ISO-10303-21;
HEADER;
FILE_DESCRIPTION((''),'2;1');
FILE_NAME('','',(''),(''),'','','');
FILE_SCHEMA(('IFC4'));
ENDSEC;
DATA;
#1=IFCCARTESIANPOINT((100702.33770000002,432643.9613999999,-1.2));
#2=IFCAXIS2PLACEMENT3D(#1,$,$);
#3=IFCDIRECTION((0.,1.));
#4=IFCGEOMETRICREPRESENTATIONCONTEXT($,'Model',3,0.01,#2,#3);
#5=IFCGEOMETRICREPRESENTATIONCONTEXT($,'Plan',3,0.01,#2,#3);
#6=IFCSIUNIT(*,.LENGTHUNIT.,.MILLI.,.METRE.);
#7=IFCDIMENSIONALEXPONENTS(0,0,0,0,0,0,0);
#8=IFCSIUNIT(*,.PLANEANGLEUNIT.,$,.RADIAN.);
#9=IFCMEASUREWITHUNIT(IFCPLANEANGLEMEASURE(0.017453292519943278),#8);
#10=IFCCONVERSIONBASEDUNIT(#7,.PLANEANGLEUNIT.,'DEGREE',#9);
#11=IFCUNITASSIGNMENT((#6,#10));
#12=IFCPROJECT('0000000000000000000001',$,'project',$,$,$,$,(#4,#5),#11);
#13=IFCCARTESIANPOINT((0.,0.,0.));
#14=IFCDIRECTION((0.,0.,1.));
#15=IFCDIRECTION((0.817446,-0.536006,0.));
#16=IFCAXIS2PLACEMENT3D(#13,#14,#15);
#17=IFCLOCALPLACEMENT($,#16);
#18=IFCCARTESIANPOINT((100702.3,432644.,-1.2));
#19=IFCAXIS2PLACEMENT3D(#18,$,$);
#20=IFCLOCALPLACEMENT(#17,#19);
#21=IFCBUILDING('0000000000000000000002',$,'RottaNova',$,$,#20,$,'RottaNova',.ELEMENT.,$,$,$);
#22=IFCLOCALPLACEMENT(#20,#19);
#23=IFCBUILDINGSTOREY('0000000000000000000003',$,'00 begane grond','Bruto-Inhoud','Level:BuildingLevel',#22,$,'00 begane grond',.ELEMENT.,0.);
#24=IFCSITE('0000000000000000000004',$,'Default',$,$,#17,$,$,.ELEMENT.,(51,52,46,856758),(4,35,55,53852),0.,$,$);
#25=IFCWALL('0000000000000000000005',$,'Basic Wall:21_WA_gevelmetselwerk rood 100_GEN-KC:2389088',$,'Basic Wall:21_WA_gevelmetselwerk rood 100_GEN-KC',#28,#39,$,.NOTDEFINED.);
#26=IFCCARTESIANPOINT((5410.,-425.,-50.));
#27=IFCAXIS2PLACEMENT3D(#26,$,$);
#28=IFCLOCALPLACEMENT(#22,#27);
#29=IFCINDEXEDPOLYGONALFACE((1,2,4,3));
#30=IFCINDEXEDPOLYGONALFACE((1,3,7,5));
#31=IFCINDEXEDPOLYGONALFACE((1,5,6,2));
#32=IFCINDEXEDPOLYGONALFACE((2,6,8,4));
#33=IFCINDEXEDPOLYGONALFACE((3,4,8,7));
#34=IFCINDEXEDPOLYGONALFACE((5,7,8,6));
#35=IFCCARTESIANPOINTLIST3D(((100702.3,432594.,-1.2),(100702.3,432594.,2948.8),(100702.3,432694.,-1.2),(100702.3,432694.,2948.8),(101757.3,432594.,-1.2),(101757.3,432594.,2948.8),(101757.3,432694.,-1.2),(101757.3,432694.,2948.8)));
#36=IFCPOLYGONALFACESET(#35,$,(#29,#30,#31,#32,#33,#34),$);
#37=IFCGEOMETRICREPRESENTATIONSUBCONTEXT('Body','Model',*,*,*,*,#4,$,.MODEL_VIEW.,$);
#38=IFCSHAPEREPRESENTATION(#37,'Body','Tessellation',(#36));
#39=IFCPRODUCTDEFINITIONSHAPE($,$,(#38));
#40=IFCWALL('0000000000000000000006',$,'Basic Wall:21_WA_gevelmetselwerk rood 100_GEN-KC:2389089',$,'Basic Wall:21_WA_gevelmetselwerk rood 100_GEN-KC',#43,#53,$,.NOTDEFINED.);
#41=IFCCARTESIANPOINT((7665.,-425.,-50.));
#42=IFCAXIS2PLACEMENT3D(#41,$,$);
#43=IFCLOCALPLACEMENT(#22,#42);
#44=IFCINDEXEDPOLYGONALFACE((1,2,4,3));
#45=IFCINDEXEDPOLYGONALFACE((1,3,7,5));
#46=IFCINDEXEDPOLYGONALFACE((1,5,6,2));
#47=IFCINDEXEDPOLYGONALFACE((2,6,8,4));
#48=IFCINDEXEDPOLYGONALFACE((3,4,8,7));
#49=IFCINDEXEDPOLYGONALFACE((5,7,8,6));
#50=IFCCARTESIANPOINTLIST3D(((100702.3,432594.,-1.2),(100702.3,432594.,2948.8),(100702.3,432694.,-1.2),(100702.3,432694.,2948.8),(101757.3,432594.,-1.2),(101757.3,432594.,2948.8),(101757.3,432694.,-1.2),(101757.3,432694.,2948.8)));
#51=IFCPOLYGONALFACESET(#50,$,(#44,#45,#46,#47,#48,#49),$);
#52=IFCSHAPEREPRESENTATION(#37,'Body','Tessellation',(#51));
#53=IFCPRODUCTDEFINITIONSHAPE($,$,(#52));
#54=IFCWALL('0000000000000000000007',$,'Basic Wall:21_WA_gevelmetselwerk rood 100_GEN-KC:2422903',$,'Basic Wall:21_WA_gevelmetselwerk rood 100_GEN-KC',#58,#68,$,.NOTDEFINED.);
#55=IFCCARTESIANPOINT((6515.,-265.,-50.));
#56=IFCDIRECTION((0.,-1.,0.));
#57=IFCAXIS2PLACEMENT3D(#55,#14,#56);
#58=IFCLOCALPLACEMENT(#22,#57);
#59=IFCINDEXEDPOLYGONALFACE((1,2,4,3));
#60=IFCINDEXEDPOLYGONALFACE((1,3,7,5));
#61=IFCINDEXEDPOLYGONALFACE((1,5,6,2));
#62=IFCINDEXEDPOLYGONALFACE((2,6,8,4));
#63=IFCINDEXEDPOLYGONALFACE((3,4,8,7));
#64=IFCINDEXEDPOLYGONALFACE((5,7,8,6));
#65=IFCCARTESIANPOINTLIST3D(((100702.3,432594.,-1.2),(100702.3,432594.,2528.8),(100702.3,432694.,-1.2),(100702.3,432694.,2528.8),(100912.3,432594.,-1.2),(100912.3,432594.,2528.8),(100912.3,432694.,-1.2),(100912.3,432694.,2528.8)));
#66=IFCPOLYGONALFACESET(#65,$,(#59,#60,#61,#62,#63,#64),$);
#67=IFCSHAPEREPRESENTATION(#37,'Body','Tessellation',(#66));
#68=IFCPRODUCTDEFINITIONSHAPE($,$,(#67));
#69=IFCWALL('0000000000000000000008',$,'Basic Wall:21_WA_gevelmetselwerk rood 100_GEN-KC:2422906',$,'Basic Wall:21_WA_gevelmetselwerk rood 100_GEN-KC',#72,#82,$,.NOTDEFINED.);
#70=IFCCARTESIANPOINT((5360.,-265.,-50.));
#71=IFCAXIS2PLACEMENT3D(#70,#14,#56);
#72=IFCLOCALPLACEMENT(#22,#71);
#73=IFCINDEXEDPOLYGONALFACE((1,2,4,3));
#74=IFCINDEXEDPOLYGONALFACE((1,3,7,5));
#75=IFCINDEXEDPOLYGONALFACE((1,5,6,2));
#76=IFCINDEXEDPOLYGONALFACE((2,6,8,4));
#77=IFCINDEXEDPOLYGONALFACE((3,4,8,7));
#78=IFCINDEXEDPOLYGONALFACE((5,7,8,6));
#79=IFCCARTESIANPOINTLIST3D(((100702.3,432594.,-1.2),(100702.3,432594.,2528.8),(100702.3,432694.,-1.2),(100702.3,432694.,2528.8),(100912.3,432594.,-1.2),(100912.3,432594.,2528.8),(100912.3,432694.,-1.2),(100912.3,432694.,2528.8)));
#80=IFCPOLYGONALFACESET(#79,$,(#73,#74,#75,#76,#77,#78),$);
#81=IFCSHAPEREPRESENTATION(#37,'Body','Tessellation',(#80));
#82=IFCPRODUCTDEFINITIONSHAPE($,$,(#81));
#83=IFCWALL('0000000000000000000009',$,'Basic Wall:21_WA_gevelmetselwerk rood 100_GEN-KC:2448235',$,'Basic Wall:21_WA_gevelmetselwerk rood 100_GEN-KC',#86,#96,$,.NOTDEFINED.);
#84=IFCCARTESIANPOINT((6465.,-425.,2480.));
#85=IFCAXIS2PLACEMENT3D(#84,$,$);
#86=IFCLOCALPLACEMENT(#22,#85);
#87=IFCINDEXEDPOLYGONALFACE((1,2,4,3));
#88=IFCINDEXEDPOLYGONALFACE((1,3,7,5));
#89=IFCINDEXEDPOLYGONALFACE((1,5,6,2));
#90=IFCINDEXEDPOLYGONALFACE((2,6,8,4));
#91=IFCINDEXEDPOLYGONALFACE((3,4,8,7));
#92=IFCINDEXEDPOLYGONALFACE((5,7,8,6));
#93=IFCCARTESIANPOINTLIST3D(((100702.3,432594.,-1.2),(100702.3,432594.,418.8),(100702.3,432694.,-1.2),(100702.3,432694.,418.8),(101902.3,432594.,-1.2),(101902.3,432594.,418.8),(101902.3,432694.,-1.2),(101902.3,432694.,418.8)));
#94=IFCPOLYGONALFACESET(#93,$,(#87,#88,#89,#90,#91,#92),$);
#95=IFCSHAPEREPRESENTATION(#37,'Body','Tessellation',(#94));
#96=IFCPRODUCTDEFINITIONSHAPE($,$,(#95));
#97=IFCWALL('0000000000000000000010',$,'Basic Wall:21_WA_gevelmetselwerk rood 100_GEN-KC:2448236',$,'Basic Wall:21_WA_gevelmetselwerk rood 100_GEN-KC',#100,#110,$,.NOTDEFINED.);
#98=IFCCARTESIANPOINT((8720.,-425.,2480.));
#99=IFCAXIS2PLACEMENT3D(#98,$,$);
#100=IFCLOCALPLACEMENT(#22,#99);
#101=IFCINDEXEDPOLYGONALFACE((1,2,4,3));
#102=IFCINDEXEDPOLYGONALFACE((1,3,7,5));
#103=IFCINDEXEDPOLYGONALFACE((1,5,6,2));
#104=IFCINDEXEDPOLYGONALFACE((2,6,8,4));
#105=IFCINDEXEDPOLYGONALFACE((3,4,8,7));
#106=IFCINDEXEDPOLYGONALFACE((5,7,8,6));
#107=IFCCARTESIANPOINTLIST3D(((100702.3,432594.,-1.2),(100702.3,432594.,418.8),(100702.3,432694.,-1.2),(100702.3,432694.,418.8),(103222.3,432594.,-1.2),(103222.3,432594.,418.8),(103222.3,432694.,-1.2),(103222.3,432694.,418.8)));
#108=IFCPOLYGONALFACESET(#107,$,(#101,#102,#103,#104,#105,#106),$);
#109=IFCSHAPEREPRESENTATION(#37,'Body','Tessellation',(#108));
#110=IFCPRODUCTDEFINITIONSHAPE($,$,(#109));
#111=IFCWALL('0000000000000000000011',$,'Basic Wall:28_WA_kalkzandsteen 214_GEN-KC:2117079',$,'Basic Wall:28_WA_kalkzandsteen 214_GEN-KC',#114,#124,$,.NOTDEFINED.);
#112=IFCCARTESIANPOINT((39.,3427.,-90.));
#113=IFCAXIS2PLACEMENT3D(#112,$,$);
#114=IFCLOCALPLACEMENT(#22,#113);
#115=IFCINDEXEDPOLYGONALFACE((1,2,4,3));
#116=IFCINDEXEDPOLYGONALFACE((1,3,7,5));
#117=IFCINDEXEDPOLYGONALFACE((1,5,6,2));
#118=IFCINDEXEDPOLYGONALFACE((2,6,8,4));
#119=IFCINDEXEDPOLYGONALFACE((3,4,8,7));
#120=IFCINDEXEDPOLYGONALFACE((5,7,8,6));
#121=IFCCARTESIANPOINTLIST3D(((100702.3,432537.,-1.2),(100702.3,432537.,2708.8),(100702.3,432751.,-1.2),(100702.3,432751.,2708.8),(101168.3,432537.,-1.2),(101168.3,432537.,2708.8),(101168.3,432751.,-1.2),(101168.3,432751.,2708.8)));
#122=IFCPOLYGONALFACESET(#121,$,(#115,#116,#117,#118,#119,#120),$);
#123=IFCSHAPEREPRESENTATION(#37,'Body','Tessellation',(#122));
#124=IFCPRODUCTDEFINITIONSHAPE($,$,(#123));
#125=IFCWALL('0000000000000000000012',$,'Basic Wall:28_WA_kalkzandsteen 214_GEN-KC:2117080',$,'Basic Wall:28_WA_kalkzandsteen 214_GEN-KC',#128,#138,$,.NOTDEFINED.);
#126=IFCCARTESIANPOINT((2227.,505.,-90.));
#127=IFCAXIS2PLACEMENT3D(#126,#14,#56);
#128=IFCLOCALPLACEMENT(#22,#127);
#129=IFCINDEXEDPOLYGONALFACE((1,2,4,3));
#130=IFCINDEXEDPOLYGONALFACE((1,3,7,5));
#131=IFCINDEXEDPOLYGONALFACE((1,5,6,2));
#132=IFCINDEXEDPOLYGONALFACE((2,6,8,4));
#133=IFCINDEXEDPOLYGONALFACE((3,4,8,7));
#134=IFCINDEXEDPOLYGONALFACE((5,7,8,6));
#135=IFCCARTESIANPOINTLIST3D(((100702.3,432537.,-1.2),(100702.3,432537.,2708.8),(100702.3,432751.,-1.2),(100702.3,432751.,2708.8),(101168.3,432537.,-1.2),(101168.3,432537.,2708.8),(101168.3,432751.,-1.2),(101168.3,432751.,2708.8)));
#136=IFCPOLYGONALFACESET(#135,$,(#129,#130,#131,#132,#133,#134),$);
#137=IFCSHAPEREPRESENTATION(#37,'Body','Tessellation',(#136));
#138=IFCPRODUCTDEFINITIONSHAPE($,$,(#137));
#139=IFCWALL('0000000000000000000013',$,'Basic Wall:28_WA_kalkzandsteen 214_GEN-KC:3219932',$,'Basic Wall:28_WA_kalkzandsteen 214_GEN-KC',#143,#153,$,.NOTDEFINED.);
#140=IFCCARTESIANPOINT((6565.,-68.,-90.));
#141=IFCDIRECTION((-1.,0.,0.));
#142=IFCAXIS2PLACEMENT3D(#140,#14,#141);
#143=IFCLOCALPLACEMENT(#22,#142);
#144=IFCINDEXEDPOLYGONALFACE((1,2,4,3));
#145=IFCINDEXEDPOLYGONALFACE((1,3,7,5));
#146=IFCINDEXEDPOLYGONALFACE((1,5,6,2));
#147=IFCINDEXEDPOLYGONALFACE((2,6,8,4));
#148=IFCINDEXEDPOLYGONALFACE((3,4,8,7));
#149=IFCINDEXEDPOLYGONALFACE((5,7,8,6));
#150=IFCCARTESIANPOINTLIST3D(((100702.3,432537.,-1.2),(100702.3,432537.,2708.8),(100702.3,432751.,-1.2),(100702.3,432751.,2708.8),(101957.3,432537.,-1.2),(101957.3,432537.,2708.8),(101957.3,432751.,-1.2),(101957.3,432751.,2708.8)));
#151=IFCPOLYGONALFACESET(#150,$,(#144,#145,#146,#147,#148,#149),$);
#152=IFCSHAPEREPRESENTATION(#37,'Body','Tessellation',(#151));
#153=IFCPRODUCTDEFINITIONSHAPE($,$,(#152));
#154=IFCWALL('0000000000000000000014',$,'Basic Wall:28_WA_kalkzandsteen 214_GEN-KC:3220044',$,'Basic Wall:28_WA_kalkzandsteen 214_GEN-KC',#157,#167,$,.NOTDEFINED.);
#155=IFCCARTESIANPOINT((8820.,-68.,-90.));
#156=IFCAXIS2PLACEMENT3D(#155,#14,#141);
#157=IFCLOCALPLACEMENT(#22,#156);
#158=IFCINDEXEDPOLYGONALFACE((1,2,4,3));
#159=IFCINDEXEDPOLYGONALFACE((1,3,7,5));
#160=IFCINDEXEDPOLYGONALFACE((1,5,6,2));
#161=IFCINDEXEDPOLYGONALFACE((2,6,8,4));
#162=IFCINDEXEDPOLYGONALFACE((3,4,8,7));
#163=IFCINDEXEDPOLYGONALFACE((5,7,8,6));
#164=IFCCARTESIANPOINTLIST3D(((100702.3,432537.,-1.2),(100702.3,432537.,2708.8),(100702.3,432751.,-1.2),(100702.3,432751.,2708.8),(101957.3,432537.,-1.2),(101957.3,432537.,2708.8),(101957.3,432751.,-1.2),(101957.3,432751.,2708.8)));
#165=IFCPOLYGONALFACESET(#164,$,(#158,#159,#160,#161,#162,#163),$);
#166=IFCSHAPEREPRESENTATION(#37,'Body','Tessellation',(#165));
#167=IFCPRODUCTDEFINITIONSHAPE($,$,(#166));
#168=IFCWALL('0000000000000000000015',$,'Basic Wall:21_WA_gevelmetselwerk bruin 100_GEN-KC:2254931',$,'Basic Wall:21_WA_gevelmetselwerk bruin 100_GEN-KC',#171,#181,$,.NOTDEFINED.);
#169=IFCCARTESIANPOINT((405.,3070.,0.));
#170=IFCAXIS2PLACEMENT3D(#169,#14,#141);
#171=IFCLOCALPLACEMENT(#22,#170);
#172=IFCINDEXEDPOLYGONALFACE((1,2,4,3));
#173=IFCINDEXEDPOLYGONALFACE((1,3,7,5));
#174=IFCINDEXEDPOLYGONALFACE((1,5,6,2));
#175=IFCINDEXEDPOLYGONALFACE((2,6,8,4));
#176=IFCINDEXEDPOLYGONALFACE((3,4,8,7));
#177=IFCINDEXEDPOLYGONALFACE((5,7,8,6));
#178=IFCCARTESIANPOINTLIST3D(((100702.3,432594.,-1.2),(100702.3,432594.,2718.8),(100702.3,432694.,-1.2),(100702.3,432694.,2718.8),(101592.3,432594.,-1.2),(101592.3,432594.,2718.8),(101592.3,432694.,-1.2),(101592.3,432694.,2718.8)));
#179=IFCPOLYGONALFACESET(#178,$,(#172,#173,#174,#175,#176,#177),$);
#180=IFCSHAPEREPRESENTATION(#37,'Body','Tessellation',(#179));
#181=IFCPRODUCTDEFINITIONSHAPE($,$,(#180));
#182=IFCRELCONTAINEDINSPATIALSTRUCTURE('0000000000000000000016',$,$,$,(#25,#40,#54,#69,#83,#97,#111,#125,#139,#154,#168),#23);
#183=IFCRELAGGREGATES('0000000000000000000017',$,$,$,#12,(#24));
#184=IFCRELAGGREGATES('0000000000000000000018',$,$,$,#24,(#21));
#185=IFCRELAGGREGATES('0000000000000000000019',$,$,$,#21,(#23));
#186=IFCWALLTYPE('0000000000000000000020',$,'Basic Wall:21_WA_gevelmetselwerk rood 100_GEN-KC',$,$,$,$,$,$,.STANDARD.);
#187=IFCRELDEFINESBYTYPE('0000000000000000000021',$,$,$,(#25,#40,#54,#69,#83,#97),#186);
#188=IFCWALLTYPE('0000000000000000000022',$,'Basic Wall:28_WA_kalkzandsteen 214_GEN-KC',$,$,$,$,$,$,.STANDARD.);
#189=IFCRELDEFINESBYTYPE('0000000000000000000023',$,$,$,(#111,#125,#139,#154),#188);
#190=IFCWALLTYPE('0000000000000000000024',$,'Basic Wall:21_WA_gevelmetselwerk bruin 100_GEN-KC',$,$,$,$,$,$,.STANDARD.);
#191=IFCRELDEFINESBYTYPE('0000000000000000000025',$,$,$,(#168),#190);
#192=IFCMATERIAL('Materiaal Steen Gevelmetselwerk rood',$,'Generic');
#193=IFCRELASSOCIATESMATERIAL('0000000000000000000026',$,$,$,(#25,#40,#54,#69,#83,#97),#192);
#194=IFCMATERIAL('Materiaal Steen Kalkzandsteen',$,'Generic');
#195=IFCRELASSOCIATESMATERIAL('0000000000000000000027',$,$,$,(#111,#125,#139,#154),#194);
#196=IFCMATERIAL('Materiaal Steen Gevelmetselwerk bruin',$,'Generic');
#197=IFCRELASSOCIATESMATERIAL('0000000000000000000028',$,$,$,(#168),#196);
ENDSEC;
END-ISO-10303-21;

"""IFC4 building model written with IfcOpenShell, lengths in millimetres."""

from ifc_helpers import new_model, entity, si_unit, converted_unit, direction, frame, place, context, subcontext, project, spatial, indexed_curve, outline, extrude, material, type_object, element, save


model = new_model("IFC4")

# Units and contexts
model_context = context("Model", 3, precision=0.01, world=frame((100702.33770000002, 432643.9613999999, -1.2)), true_north=direction((0.0, 1.0)))
plan_context = context("Plan", 3, precision=0.01, world=frame((100702.33770000002, 432643.9613999999, -1.2)), true_north=direction((0.0, 1.0)))
body_context = subcontext(model_context, "Body", "Model", "MODEL_VIEW")
ifc_project = project(units=[si_unit("LENGTHUNIT", "METRE", prefix="MILLI"), converted_unit("PLANEANGLEUNIT", "DEGREE", entity("IfcPlaneAngleMeasure", 0.017453292519943278), si_unit("PLANEANGLEUNIT", "RADIAN"), dimensions=[0, 0, 0, 0, 0, 0, 0])], contexts=[model_context, plan_context])

# Site, building, storey
site_placement = place(None, frame((0.0, 0.0, 0.0), z_axis=(0.0, 0.0, 1.0), x_axis=(0.817446, -0.536006, 0.0)))
site = spatial("IfcSite", under=ifc_project, at=site_placement, Name="Default", CompositionType="ELEMENT", RefLatitude=(51, 52, 46, 856758), RefLongitude=(4, 35, 55, 53852), RefElevation=0.0)
building_placement = place(site_placement, frame((100702.3, 432644.0, -1.2)))
building = spatial("IfcBuilding", under=site, at=building_placement, Name="RottaNova", LongName="RottaNova", CompositionType="ELEMENT")
storey_placement = place(building_placement, frame((100702.3, 432644.0, -1.2)))
storey = spatial("IfcBuildingStorey", under=building, at=storey_placement, Name="00 begane grond", Description="Bruto-Inhoud", ObjectType="Level:BuildingLevel", LongName="00 begane grond", CompositionType="ELEMENT", Elevation=0.0)

# Walls
ifc_material_1 = material(Name="Materiaal Steen Gevelmetselwerk rood", Category="Generic")
wall_type_1 = type_object("IfcWallType", Name="Basic Wall:21_WA_gevelmetselwerk rood 100_GEN-KC", PredefinedType="STANDARD")
wall_1_placement = place(storey_placement, frame((5410.0, -425.0, -50.0)))
element("IfcWall", 1, at=wall_1_placement, inside=storey, type_object=wall_type_1, material=ifc_material_1, Name="Basic Wall:21_WA_gevelmetselwerk rood 100_GEN-KC:2389088", ObjectType="Basic Wall:21_WA_gevelmetselwerk rood 100_GEN-KC", PredefinedType="NOTDEFINED", context=body_context, shape_type="SweptSolid", body=[
    extrude(outline(indexed_curve([(1055.0, 50.0), (0.0, 50.0), (0.0, -50.0), (1055.0, -50.0), (1055.0, 50.0)], self_intersect=False)), frame((100702.3, 432644.0, -1.2)), (0.0, 0.0, 1.0), 2950.0),
])
wall_2_placement = place(storey_placement, frame((7665.0, -425.0, -50.0)))
element("IfcWall", 2, at=wall_2_placement, inside=storey, type_object=wall_type_1, material=ifc_material_1, Name="Basic Wall:21_WA_gevelmetselwerk rood 100_GEN-KC:2389089", ObjectType="Basic Wall:21_WA_gevelmetselwerk rood 100_GEN-KC", PredefinedType="NOTDEFINED", context=body_context, shape_type="SweptSolid", body=[
    extrude(outline(indexed_curve([(1055.0, 50.0), (0.0, 50.0), (0.0, -50.0), (1055.0, -50.0), (1055.0, 50.0)], self_intersect=False)), frame((100702.3, 432644.0, -1.2)), (0.0, 0.0, 1.0), 2950.0),
])
wall_3_placement = place(storey_placement, frame((6515.0, -265.0, -50.0), z_axis=(0.0, 0.0, 1.0), x_axis=(0.0, -1.0, 0.0)))
element("IfcWall", 3, at=wall_3_placement, inside=storey, type_object=wall_type_1, material=ifc_material_1, Name="Basic Wall:21_WA_gevelmetselwerk rood 100_GEN-KC:2422903", ObjectType="Basic Wall:21_WA_gevelmetselwerk rood 100_GEN-KC", PredefinedType="NOTDEFINED", context=body_context, shape_type="SweptSolid", body=[
    extrude(outline(indexed_curve([(210.0, 50.0), (0.0, 50.0), (0.0, -50.0), (210.0, -50.0), (210.0, 50.0)], self_intersect=False)), frame((100702.3, 432644.0, -1.2)), (0.0, 0.0, 1.0), 2530.0),
])
wall_4_placement = place(storey_placement, frame((5360.0, -265.0, -50.0), z_axis=(0.0, 0.0, 1.0), x_axis=(0.0, -1.0, 0.0)))
element("IfcWall", 4, at=wall_4_placement, inside=storey, type_object=wall_type_1, material=ifc_material_1, Name="Basic Wall:21_WA_gevelmetselwerk rood 100_GEN-KC:2422906", ObjectType="Basic Wall:21_WA_gevelmetselwerk rood 100_GEN-KC", PredefinedType="NOTDEFINED", context=body_context, shape_type="SweptSolid", body=[
    extrude(outline(indexed_curve([(210.0, 50.0), (0.0, 50.0), (0.0, -50.0), (210.0, -50.0), (210.0, 50.0)], self_intersect=False)), frame((100702.3, 432644.0, -1.2)), (0.0, 0.0, 1.0), 2530.0),
])
wall_5_placement = place(storey_placement, frame((6465.0, -425.0, 2480.0)))
element("IfcWall", 5, at=wall_5_placement, inside=storey, type_object=wall_type_1, material=ifc_material_1, Name="Basic Wall:21_WA_gevelmetselwerk rood 100_GEN-KC:2448235", ObjectType="Basic Wall:21_WA_gevelmetselwerk rood 100_GEN-KC", PredefinedType="NOTDEFINED", context=body_context, shape_type="SweptSolid", body=[
    extrude(outline(indexed_curve([(1200.0, 50.0), (0.0, 50.0), (0.0, -50.0), (1200.0, -50.0), (1200.0, 50.0)], self_intersect=False)), frame((100702.3, 432644.0, -1.2)), (0.0, 0.0, 1.0), 420.0),
])
wall_6_placement = place(storey_placement, frame((8720.0, -425.0, 2480.0)))
element("IfcWall", 6, at=wall_6_placement, inside=storey, type_object=wall_type_1, material=ifc_material_1, Name="Basic Wall:21_WA_gevelmetselwerk rood 100_GEN-KC:2448236", ObjectType="Basic Wall:21_WA_gevelmetselwerk rood 100_GEN-KC", PredefinedType="NOTDEFINED", context=body_context, shape_type="SweptSolid", body=[
    extrude(outline(indexed_curve([(2520.0, 50.0), (0.0, 50.0), (0.0, -50.0), (2520.0, -50.0), (2520.0, 50.0)], self_intersect=False)), frame((100702.3, 432644.0, -1.2)), (0.0, 0.0, 1.0), 420.0),
])
ifc_material_2 = material(Name="Materiaal Steen Kalkzandsteen", Category="Generic")
wall_type_2 = type_object("IfcWallType", Name="Basic Wall:28_WA_kalkzandsteen 214_GEN-KC", PredefinedType="STANDARD")
wall_7_placement = place(storey_placement, frame((39.0, 3427.0, -90.0)))
element("IfcWall", 7, at=wall_7_placement, inside=storey, type_object=wall_type_2, material=ifc_material_2, Name="Basic Wall:28_WA_kalkzandsteen 214_GEN-KC:2117079", ObjectType="Basic Wall:28_WA_kalkzandsteen 214_GEN-KC", PredefinedType="NOTDEFINED", context=body_context, shape_type="SweptSolid", body=[
    extrude(outline(indexed_curve([(466.0, 107.0), (0.0, 107.0), (0.0, -107.0), (466.0, -107.0), (466.0, 107.0)], self_intersect=False)), frame((100702.3, 432644.0, -1.2)), (0.0, 0.0, 1.0), 2710.0),
])
wall_8_placement = place(storey_placement, frame((2227.0, 505.0, -90.0), z_axis=(0.0, 0.0, 1.0), x_axis=(0.0, -1.0, 0.0)))
element("IfcWall", 8, at=wall_8_placement, inside=storey, type_object=wall_type_2, material=ifc_material_2, Name="Basic Wall:28_WA_kalkzandsteen 214_GEN-KC:2117080", ObjectType="Basic Wall:28_WA_kalkzandsteen 214_GEN-KC", PredefinedType="NOTDEFINED", context=body_context, shape_type="SweptSolid", body=[
    extrude(outline(indexed_curve([(466.0, 107.0), (0.0, 107.0), (0.0, -107.0), (466.0, -107.0), (466.0, 107.0)], self_intersect=False)), frame((100702.3, 432644.0, -1.2)), (0.0, 0.0, 1.0), 2710.0),
])
wall_9_placement = place(storey_placement, frame((6565.0, -68.0, -90.0), z_axis=(0.0, 0.0, 1.0), x_axis=(-1.0, 0.0, 0.0)))
element("IfcWall", 9, at=wall_9_placement, inside=storey, type_object=wall_type_2, material=ifc_material_2, Name="Basic Wall:28_WA_kalkzandsteen 214_GEN-KC:3219932", ObjectType="Basic Wall:28_WA_kalkzandsteen 214_GEN-KC", PredefinedType="NOTDEFINED", context=body_context, shape_type="SweptSolid", body=[
    extrude(outline(indexed_curve([(1255.0, 107.0), (0.0, 107.0), (0.0, -107.0), (1255.0, -107.0), (1255.0, 107.0)], self_intersect=False)), frame((100702.3, 432644.0, -1.2)), (0.0, 0.0, 1.0), 2710.0),
])
wall_10_placement = place(storey_placement, frame((8820.0, -68.0, -90.0), z_axis=(0.0, 0.0, 1.0), x_axis=(-1.0, 0.0, 0.0)))
element("IfcWall", 10, at=wall_10_placement, inside=storey, type_object=wall_type_2, material=ifc_material_2, Name="Basic Wall:28_WA_kalkzandsteen 214_GEN-KC:3220044", ObjectType="Basic Wall:28_WA_kalkzandsteen 214_GEN-KC", PredefinedType="NOTDEFINED", context=body_context, shape_type="SweptSolid", body=[
    extrude(outline(indexed_curve([(1255.0, 107.0), (0.0, 107.0), (0.0, -107.0), (1255.0, -107.0), (1255.0, 107.0)], self_intersect=False)), frame((100702.3, 432644.0, -1.2)), (0.0, 0.0, 1.0), 2710.0),
])
ifc_material_3 = material(Name="Materiaal Steen Gevelmetselwerk bruin", Category="Generic")
wall_type_3 = type_object("IfcWallType", Name="Basic Wall:21_WA_gevelmetselwerk bruin 100_GEN-KC", PredefinedType="STANDARD")
wall_11_placement = place(storey_placement, frame((405.0, 3070.0, 0.0), z_axis=(0.0, 0.0, 1.0), x_axis=(-1.0, 0.0, 0.0)))
element("IfcWall", 11, at=wall_11_placement, inside=storey, type_object=wall_type_3, material=ifc_material_3, Name="Basic Wall:21_WA_gevelmetselwerk bruin 100_GEN-KC:2254931", ObjectType="Basic Wall:21_WA_gevelmetselwerk bruin 100_GEN-KC", PredefinedType="NOTDEFINED", context=body_context, shape_type="SweptSolid", body=[
    extrude(outline(indexed_curve([(890.0, 50.0), (0.0, 50.0), (0.0, -50.0), (890.0, -50.0), (890.0, 50.0)], self_intersect=False)), frame((100702.3, 432644.0, -1.2)), (0.0, 0.0, 1.0), 2720.0),
])

save(model, "model.ifc")
